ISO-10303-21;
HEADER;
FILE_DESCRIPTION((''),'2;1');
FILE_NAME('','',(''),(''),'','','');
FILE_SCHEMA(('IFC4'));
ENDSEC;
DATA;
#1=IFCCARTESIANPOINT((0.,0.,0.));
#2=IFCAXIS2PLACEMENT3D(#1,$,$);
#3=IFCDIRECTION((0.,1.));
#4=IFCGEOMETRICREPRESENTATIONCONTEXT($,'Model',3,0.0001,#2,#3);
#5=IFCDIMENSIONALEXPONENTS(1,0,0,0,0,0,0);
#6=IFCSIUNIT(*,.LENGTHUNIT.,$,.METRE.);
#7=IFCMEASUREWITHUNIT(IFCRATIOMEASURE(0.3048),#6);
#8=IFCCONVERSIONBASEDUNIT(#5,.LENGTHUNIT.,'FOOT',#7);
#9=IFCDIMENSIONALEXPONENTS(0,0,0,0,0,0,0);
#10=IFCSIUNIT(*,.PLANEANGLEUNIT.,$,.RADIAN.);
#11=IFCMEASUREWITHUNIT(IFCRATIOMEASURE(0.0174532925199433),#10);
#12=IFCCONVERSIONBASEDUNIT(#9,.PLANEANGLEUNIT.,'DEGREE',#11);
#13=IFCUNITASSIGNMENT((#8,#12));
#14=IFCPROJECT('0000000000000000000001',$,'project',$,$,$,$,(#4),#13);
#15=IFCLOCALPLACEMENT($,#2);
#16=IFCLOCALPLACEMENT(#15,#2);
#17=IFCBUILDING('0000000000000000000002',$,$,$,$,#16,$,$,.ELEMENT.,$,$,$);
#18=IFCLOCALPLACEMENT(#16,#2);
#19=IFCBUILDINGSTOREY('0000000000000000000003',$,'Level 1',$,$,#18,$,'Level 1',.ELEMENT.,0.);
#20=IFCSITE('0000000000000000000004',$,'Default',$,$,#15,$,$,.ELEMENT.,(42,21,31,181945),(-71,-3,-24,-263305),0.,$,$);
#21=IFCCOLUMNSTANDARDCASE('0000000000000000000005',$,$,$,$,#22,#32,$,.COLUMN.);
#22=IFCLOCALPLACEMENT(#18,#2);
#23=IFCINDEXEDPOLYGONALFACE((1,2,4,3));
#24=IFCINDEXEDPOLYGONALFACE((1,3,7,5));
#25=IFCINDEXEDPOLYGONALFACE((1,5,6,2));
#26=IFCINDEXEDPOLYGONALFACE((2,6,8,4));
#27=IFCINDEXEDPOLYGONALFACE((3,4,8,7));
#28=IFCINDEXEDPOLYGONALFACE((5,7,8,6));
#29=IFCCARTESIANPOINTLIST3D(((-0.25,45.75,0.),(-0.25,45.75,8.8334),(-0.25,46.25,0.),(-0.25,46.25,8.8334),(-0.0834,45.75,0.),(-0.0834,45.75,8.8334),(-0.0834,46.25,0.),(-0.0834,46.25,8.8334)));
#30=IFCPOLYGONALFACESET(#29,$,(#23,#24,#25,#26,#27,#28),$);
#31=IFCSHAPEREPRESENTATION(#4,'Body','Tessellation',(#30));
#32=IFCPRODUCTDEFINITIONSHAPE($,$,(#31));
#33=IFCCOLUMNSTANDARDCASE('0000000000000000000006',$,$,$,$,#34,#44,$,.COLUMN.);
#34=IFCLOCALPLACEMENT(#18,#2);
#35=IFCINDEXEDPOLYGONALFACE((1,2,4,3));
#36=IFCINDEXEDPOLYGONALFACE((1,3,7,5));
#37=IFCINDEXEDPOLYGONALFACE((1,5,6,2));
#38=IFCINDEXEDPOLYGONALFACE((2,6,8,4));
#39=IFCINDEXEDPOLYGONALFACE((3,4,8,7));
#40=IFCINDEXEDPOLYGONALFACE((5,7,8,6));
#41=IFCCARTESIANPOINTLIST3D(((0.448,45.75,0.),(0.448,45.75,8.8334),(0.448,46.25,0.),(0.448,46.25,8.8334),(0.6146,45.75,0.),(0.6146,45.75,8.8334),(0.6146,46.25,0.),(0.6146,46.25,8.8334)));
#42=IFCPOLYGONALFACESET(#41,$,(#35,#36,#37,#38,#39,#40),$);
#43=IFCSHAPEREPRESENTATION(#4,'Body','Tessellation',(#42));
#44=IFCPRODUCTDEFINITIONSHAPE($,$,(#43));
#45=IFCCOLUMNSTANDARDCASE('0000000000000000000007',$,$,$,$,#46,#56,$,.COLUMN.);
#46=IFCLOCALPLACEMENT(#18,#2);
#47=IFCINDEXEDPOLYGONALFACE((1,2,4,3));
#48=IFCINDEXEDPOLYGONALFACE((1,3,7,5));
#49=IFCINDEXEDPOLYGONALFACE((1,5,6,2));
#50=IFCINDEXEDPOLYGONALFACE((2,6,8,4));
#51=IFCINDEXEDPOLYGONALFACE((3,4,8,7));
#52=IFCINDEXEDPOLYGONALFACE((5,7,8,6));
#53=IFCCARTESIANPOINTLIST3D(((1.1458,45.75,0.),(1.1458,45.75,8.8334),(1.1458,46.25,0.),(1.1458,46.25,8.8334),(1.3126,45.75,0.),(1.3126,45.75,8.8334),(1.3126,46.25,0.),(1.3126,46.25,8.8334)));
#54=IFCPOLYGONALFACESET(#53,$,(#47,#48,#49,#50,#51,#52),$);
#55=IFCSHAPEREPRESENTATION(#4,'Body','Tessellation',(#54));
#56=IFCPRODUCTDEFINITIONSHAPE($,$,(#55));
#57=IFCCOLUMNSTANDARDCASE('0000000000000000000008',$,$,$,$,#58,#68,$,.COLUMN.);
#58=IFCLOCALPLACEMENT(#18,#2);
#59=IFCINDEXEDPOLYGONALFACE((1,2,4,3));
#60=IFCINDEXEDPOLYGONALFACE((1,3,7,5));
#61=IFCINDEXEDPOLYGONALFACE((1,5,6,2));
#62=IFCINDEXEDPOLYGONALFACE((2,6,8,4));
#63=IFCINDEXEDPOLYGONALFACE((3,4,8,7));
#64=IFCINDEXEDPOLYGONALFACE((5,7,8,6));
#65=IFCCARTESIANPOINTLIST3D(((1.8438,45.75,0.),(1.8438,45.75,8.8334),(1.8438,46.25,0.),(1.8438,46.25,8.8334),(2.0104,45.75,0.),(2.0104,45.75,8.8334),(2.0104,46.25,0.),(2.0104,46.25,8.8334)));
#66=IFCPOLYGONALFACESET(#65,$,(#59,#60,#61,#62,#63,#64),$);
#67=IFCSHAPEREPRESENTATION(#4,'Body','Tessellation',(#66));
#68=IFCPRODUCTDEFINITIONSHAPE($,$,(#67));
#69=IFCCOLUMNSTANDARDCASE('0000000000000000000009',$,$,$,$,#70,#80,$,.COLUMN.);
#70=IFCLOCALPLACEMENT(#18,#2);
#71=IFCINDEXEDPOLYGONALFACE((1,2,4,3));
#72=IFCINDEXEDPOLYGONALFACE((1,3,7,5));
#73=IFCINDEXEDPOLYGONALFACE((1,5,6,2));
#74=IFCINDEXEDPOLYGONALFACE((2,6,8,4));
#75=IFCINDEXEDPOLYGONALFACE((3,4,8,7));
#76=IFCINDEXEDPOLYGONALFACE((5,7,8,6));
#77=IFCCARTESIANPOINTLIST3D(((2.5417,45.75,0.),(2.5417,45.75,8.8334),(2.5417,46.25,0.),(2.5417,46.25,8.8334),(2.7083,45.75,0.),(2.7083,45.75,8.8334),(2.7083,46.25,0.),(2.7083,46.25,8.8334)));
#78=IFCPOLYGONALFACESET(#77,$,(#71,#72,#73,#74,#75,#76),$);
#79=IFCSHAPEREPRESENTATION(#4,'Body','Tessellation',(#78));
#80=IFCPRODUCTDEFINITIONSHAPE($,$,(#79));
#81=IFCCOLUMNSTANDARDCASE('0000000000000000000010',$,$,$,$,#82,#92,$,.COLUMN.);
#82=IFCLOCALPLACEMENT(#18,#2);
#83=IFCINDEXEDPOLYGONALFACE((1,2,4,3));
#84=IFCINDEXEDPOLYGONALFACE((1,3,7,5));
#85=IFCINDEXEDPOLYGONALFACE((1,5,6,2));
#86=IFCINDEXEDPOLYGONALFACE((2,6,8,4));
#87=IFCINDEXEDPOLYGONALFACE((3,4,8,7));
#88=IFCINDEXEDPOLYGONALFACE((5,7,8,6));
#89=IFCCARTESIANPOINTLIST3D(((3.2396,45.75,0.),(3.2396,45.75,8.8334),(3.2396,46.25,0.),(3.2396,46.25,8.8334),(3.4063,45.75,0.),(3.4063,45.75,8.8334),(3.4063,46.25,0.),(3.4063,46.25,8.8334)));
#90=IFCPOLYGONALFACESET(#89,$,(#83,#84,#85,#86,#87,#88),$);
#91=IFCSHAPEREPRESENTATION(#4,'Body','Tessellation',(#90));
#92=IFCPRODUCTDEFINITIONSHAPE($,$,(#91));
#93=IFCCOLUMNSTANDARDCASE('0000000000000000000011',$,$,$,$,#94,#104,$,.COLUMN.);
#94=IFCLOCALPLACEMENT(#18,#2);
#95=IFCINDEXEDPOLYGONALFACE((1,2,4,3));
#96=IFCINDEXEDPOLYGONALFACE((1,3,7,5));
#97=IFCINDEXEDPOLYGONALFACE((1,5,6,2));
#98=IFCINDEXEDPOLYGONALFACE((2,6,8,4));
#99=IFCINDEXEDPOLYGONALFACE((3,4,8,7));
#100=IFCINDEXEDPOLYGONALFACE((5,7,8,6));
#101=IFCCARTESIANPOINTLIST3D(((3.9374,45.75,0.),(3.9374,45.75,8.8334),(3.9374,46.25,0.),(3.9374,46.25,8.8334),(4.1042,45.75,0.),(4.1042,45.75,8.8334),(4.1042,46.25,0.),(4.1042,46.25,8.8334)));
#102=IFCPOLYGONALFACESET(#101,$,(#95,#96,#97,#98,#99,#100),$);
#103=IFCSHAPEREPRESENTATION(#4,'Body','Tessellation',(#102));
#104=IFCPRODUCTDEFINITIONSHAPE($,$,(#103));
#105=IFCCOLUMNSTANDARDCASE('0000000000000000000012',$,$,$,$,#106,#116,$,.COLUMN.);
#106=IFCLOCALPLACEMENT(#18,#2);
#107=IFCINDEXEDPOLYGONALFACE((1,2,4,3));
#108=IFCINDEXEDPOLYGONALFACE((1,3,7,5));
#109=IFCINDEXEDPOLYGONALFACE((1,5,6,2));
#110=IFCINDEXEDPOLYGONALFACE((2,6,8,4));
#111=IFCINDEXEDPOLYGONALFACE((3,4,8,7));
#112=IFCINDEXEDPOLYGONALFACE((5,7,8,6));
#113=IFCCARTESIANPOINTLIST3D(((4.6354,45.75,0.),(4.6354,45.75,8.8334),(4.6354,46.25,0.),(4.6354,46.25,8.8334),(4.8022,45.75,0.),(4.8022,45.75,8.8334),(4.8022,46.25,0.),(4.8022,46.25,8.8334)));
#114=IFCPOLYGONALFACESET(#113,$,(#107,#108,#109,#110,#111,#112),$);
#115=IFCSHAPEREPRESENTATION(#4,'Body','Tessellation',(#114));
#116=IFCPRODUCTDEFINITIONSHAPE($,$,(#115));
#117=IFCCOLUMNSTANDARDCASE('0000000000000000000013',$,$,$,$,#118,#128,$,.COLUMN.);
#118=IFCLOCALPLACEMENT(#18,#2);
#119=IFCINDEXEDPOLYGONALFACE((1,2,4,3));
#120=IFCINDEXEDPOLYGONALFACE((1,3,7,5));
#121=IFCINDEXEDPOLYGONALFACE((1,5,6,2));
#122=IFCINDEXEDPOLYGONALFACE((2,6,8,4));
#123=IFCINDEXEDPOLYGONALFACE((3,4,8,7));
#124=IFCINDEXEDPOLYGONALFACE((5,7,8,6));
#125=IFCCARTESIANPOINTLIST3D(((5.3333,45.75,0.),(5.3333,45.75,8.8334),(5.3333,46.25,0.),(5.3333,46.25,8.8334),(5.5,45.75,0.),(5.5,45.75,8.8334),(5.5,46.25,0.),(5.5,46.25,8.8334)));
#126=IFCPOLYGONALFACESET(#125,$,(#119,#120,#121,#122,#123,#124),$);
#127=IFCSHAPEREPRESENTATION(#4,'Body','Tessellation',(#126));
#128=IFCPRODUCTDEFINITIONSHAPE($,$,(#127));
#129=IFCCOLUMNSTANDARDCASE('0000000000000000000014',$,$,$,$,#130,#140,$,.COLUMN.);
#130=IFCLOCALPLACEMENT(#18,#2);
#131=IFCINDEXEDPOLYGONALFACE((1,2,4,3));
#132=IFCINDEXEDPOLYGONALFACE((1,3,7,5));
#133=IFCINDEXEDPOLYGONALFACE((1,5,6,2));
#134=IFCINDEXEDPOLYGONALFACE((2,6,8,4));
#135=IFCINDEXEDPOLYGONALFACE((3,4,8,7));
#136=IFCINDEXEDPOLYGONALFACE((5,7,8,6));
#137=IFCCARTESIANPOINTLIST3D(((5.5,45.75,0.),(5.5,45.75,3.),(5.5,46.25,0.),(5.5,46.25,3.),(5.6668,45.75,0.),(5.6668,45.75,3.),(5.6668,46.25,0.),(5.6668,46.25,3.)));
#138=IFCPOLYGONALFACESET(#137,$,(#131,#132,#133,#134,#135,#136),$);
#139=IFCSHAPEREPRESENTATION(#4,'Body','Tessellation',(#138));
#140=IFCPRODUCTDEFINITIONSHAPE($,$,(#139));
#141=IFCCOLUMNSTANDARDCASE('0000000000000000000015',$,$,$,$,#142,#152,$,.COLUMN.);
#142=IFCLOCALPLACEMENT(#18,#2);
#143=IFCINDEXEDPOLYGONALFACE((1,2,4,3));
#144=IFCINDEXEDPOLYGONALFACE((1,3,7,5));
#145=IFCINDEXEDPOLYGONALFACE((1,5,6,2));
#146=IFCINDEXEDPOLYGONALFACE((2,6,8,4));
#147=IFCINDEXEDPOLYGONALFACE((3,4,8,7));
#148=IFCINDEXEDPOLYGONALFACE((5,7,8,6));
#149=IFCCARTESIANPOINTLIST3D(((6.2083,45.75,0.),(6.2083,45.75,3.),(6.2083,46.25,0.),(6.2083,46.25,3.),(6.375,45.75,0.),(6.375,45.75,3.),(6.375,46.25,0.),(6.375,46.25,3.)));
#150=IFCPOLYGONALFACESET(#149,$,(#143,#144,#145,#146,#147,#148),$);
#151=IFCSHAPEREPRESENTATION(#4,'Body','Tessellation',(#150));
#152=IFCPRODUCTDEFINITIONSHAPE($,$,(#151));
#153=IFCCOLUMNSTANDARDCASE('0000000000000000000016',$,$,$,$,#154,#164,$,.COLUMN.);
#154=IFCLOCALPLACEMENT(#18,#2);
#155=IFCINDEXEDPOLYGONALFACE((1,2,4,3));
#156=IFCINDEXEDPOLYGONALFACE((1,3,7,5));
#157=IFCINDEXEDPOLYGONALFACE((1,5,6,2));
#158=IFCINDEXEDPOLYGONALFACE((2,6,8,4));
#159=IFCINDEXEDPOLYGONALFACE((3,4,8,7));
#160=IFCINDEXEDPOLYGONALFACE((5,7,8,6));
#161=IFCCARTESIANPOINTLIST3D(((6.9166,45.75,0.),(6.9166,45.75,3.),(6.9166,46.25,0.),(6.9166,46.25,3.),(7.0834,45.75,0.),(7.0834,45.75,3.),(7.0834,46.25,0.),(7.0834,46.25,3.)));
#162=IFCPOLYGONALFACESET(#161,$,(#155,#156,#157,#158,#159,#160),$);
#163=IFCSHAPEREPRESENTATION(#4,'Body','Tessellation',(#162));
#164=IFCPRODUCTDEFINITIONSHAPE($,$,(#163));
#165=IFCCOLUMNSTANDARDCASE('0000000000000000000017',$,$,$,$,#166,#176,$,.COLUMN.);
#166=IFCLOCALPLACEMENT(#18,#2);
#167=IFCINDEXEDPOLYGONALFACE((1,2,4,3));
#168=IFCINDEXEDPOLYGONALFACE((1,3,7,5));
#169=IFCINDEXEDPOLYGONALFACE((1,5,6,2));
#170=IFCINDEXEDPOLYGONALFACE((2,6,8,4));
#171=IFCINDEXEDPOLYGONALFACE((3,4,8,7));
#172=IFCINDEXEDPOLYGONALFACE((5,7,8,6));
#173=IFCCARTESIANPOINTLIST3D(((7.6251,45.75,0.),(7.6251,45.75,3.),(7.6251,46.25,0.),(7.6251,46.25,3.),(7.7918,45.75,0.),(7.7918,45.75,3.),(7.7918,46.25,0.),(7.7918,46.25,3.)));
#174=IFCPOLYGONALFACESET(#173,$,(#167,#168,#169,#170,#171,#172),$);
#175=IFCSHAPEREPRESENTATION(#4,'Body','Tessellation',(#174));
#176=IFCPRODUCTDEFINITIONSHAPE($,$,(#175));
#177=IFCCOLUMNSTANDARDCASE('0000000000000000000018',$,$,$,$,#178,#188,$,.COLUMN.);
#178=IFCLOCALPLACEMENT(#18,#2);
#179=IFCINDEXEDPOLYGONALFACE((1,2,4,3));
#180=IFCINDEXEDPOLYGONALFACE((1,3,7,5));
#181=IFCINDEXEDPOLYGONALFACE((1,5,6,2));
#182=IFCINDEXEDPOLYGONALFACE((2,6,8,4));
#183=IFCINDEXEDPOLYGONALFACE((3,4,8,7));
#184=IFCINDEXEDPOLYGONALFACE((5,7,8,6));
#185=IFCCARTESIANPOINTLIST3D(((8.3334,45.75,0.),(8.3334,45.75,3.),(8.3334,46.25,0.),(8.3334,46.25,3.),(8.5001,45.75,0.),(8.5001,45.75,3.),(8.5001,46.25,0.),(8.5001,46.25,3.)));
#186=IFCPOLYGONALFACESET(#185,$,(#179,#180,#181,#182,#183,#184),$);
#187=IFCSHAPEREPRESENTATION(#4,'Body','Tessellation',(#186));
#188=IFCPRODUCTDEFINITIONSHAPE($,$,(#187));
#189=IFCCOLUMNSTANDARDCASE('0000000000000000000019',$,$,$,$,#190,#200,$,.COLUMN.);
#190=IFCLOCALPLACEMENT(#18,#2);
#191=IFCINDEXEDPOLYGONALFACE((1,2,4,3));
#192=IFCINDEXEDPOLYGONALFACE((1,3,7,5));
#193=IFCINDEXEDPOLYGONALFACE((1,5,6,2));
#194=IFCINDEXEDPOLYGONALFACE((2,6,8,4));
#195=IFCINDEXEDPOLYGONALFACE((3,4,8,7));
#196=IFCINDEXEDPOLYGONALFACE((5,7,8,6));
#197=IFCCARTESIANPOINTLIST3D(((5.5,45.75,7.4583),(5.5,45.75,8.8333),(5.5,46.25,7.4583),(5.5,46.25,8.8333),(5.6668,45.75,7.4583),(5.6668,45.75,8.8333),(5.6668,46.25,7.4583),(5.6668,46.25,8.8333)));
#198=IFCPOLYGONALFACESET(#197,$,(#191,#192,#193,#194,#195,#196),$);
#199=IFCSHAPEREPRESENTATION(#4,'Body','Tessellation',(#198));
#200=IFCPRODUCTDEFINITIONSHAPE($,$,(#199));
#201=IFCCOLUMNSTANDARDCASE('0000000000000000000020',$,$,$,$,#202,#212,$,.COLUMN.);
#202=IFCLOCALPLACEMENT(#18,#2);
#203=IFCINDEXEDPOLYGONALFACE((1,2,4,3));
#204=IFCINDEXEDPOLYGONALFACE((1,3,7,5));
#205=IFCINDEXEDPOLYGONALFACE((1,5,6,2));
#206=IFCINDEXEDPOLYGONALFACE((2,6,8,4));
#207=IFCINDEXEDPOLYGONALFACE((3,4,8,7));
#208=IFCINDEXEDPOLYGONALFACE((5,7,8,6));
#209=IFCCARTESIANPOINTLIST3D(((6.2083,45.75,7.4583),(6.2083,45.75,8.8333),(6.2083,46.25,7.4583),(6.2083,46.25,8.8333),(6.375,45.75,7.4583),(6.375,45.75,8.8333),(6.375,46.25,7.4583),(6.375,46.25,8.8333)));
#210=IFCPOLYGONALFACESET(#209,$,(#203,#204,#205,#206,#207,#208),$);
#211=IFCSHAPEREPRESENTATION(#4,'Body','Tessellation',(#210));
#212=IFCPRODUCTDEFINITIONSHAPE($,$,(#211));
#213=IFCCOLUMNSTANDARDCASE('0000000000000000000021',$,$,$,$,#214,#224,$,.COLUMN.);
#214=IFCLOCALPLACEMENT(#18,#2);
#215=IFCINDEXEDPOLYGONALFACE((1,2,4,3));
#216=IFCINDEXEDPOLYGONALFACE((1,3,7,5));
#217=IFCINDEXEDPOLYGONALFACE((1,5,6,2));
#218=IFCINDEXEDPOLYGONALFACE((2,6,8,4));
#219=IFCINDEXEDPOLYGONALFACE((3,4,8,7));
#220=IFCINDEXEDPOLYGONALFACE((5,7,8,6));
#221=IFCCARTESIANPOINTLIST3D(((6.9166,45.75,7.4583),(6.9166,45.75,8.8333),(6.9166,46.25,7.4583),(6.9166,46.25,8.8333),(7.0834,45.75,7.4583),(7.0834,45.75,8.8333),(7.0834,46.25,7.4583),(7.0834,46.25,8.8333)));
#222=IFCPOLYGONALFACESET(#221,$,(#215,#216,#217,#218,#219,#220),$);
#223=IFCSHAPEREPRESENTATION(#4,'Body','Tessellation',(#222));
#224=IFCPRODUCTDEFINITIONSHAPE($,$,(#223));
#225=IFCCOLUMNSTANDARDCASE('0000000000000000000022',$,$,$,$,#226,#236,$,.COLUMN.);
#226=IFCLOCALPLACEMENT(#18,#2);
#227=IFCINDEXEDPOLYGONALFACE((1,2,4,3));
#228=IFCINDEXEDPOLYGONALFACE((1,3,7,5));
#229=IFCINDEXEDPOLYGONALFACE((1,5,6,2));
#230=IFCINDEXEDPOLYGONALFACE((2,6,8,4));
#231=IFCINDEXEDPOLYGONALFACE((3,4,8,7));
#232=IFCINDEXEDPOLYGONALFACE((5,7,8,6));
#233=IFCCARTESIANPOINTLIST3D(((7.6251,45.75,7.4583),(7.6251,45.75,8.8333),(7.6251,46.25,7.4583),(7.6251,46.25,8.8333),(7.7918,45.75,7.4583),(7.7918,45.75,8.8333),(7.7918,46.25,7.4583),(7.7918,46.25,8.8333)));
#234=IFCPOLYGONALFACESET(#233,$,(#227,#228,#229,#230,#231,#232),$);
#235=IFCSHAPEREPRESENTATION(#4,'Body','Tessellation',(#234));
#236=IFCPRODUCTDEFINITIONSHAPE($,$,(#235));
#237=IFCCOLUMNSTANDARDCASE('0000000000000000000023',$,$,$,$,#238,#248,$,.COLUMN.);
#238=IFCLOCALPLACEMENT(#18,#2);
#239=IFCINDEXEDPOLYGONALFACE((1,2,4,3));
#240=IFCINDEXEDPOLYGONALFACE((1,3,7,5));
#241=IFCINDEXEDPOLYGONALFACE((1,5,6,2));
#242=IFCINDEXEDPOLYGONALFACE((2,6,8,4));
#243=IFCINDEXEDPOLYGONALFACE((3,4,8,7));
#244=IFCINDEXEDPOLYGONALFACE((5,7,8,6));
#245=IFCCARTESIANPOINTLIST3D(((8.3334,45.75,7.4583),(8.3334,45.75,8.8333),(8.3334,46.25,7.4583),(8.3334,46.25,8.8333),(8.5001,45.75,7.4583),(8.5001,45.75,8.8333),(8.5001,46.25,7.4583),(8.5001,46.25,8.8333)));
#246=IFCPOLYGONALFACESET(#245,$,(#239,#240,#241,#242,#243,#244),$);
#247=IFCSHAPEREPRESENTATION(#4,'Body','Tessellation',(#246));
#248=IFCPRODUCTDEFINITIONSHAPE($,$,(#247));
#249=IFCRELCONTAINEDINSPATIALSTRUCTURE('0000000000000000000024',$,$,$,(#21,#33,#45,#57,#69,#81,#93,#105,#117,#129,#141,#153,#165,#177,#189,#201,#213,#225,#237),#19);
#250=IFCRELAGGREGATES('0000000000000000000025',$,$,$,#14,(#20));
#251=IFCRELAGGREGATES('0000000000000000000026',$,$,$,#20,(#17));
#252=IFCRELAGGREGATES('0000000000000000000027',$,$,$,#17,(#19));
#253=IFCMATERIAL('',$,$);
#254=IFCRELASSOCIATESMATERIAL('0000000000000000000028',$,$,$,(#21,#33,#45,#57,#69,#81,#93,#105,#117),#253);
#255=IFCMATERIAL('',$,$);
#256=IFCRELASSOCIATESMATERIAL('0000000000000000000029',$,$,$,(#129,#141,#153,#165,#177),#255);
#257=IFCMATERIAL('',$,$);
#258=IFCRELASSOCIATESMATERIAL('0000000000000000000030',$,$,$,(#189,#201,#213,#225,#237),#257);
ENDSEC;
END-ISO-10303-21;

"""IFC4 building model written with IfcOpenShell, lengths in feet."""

from ifc_helpers import new_model, entity, si_unit, converted_unit, direction, frame, origin, place, context, project, spatial, rectangle, extrude, material, element, save


model = new_model("IFC4")

# Units and contexts
model_context = context("Model", 3, precision=0.0001, world=origin(), true_north=direction((0.0, 1.0)))
ifc_project = project(units=[converted_unit("LENGTHUNIT", "FOOT", entity("IfcRatioMeasure", 0.3048), si_unit("LENGTHUNIT", "METRE"), dimensions=[1, 0, 0, 0, 0, 0, 0]), converted_unit("PLANEANGLEUNIT", "DEGREE", entity("IfcRatioMeasure", 0.0174532925199433), si_unit("PLANEANGLEUNIT", "RADIAN"), dimensions=[0, 0, 0, 0, 0, 0, 0])], contexts=[model_context])

# Site, building, storey
site_placement = place(None, origin())
site = spatial("IfcSite", under=ifc_project, at=site_placement, Name="Default", CompositionType="ELEMENT", RefLatitude=(42, 21, 31, 181945), RefLongitude=(-71, -3, -24, -263305), RefElevation=0.0)
building_placement = place(site_placement, origin())
building = spatial("IfcBuilding", under=site, at=building_placement, CompositionType="ELEMENT")
storey_placement = place(building_placement, origin())
storey = spatial("IfcBuildingStorey", under=building, at=storey_placement, Name="Level 1", LongName="Level 1", CompositionType="ELEMENT", Elevation=0.0)

# Columns
ifc_material_1 = material(Name="")
placement_1 = place(storey_placement, frame((-0.25, 46.0, 0.0)))
for number, where, z_axis, x_axis in (
    (1, (0.0833, 0.0, 0.0), (0.0, 0.0, 1.0), (1.0, 0.0, 0.0)),
    (2, (0.7813, 0.0, 0.0), (0.0, 0.0, 1.0), (1.0, 0.0, 0.0)),
    (3, (1.4792, 0.0, 0.0), (0.0, 0.0, 1.0), (1.0, 0.0, 0.0)),
    (4, (2.1771, 0.0, 0.0), (0.0, 0.0, 1.0), (1.0, 0.0, 0.0)),
    (5, (2.875, 0.0, 0.0), (0.0, 0.0, 1.0), (1.0, 0.0, 0.0)),
    (6, (3.5729, 0.0, 0.0), (0.0, 0.0, 1.0), (1.0, 0.0, 0.0)),
    (7, (4.2708, 0.0, 0.0), (0.0, 0.0, 1.0), (1.0, 0.0, 0.0)),
    (8, (4.9688, 0.0, 0.0), (0.0, 0.0, 1.0), (1.0, 0.0, 0.0)),
    (9, (5.6667, 0.0, 0.0), (0.0, 0.0, 1.0), (1.0, 0.0, 0.0)),
):
    element("IfcColumnStandardCase", number, at=place(placement_1, frame(where, z_axis=z_axis, x_axis=x_axis)), inside=storey, material=ifc_material_1, PredefinedType="COLUMN", context=model_context, shape_type="SweptSolid", body=[
        extrude(rectangle(XDim=0.1667, YDim=0.5), origin(), (0.0, 0.0, 1.0), 8.8334),
    ])
ifc_material_2 = material(Name="")
for number, where, z_axis, x_axis in (
    (10, (5.8334, 0.0, 0.0), (0.0, 0.0, 1.0), (1.0, 0.0, 0.0)),
    (11, (6.5417, 0.0, 0.0), (0.0, 0.0, 1.0), (1.0, 0.0, 0.0)),
    (12, (7.25, 0.0, 0.0), (0.0, 0.0, 1.0), (1.0, 0.0, 0.0)),
    (13, (7.9584, 0.0, 0.0), (0.0, 0.0, 1.0), (1.0, 0.0, 0.0)),
    (14, (8.6667, 0.0, 0.0), (0.0, 0.0, 1.0), (1.0, 0.0, 0.0)),
):
    element("IfcColumnStandardCase", number, at=place(placement_1, frame(where, z_axis=z_axis, x_axis=x_axis)), inside=storey, material=ifc_material_2, PredefinedType="COLUMN", context=model_context, shape_type="SweptSolid", body=[
        extrude(rectangle(XDim=0.1667, YDim=0.5), origin(), (0.0, 0.0, 1.0), 3.0),
    ])
ifc_material_3 = material(Name="")
for number, where, z_axis, x_axis in (
    (15, (5.8334, 0.0, 7.4583), (0.0, 0.0, 1.0), (1.0, 0.0, 0.0)),
    (16, (6.5417, 0.0, 7.4583), (0.0, 0.0, 1.0), (1.0, 0.0, 0.0)),
    (17, (7.25, 0.0, 7.4583), (0.0, 0.0, 1.0), (1.0, 0.0, 0.0)),
    (18, (7.9584, 0.0, 7.4583), (0.0, 0.0, 1.0), (1.0, 0.0, 0.0)),
    (19, (8.6667, 0.0, 7.4583), (0.0, 0.0, 1.0), (1.0, 0.0, 0.0)),
):
    element("IfcColumnStandardCase", number, at=place(placement_1, frame(where, z_axis=z_axis, x_axis=x_axis)), inside=storey, material=ifc_material_3, PredefinedType="COLUMN", context=model_context, shape_type="SweptSolid", body=[
        extrude(rectangle(XDim=0.1667, YDim=0.5), origin(), (0.0, 0.0, 1.0), 1.375),
    ])

save(model, "model.ifc")
